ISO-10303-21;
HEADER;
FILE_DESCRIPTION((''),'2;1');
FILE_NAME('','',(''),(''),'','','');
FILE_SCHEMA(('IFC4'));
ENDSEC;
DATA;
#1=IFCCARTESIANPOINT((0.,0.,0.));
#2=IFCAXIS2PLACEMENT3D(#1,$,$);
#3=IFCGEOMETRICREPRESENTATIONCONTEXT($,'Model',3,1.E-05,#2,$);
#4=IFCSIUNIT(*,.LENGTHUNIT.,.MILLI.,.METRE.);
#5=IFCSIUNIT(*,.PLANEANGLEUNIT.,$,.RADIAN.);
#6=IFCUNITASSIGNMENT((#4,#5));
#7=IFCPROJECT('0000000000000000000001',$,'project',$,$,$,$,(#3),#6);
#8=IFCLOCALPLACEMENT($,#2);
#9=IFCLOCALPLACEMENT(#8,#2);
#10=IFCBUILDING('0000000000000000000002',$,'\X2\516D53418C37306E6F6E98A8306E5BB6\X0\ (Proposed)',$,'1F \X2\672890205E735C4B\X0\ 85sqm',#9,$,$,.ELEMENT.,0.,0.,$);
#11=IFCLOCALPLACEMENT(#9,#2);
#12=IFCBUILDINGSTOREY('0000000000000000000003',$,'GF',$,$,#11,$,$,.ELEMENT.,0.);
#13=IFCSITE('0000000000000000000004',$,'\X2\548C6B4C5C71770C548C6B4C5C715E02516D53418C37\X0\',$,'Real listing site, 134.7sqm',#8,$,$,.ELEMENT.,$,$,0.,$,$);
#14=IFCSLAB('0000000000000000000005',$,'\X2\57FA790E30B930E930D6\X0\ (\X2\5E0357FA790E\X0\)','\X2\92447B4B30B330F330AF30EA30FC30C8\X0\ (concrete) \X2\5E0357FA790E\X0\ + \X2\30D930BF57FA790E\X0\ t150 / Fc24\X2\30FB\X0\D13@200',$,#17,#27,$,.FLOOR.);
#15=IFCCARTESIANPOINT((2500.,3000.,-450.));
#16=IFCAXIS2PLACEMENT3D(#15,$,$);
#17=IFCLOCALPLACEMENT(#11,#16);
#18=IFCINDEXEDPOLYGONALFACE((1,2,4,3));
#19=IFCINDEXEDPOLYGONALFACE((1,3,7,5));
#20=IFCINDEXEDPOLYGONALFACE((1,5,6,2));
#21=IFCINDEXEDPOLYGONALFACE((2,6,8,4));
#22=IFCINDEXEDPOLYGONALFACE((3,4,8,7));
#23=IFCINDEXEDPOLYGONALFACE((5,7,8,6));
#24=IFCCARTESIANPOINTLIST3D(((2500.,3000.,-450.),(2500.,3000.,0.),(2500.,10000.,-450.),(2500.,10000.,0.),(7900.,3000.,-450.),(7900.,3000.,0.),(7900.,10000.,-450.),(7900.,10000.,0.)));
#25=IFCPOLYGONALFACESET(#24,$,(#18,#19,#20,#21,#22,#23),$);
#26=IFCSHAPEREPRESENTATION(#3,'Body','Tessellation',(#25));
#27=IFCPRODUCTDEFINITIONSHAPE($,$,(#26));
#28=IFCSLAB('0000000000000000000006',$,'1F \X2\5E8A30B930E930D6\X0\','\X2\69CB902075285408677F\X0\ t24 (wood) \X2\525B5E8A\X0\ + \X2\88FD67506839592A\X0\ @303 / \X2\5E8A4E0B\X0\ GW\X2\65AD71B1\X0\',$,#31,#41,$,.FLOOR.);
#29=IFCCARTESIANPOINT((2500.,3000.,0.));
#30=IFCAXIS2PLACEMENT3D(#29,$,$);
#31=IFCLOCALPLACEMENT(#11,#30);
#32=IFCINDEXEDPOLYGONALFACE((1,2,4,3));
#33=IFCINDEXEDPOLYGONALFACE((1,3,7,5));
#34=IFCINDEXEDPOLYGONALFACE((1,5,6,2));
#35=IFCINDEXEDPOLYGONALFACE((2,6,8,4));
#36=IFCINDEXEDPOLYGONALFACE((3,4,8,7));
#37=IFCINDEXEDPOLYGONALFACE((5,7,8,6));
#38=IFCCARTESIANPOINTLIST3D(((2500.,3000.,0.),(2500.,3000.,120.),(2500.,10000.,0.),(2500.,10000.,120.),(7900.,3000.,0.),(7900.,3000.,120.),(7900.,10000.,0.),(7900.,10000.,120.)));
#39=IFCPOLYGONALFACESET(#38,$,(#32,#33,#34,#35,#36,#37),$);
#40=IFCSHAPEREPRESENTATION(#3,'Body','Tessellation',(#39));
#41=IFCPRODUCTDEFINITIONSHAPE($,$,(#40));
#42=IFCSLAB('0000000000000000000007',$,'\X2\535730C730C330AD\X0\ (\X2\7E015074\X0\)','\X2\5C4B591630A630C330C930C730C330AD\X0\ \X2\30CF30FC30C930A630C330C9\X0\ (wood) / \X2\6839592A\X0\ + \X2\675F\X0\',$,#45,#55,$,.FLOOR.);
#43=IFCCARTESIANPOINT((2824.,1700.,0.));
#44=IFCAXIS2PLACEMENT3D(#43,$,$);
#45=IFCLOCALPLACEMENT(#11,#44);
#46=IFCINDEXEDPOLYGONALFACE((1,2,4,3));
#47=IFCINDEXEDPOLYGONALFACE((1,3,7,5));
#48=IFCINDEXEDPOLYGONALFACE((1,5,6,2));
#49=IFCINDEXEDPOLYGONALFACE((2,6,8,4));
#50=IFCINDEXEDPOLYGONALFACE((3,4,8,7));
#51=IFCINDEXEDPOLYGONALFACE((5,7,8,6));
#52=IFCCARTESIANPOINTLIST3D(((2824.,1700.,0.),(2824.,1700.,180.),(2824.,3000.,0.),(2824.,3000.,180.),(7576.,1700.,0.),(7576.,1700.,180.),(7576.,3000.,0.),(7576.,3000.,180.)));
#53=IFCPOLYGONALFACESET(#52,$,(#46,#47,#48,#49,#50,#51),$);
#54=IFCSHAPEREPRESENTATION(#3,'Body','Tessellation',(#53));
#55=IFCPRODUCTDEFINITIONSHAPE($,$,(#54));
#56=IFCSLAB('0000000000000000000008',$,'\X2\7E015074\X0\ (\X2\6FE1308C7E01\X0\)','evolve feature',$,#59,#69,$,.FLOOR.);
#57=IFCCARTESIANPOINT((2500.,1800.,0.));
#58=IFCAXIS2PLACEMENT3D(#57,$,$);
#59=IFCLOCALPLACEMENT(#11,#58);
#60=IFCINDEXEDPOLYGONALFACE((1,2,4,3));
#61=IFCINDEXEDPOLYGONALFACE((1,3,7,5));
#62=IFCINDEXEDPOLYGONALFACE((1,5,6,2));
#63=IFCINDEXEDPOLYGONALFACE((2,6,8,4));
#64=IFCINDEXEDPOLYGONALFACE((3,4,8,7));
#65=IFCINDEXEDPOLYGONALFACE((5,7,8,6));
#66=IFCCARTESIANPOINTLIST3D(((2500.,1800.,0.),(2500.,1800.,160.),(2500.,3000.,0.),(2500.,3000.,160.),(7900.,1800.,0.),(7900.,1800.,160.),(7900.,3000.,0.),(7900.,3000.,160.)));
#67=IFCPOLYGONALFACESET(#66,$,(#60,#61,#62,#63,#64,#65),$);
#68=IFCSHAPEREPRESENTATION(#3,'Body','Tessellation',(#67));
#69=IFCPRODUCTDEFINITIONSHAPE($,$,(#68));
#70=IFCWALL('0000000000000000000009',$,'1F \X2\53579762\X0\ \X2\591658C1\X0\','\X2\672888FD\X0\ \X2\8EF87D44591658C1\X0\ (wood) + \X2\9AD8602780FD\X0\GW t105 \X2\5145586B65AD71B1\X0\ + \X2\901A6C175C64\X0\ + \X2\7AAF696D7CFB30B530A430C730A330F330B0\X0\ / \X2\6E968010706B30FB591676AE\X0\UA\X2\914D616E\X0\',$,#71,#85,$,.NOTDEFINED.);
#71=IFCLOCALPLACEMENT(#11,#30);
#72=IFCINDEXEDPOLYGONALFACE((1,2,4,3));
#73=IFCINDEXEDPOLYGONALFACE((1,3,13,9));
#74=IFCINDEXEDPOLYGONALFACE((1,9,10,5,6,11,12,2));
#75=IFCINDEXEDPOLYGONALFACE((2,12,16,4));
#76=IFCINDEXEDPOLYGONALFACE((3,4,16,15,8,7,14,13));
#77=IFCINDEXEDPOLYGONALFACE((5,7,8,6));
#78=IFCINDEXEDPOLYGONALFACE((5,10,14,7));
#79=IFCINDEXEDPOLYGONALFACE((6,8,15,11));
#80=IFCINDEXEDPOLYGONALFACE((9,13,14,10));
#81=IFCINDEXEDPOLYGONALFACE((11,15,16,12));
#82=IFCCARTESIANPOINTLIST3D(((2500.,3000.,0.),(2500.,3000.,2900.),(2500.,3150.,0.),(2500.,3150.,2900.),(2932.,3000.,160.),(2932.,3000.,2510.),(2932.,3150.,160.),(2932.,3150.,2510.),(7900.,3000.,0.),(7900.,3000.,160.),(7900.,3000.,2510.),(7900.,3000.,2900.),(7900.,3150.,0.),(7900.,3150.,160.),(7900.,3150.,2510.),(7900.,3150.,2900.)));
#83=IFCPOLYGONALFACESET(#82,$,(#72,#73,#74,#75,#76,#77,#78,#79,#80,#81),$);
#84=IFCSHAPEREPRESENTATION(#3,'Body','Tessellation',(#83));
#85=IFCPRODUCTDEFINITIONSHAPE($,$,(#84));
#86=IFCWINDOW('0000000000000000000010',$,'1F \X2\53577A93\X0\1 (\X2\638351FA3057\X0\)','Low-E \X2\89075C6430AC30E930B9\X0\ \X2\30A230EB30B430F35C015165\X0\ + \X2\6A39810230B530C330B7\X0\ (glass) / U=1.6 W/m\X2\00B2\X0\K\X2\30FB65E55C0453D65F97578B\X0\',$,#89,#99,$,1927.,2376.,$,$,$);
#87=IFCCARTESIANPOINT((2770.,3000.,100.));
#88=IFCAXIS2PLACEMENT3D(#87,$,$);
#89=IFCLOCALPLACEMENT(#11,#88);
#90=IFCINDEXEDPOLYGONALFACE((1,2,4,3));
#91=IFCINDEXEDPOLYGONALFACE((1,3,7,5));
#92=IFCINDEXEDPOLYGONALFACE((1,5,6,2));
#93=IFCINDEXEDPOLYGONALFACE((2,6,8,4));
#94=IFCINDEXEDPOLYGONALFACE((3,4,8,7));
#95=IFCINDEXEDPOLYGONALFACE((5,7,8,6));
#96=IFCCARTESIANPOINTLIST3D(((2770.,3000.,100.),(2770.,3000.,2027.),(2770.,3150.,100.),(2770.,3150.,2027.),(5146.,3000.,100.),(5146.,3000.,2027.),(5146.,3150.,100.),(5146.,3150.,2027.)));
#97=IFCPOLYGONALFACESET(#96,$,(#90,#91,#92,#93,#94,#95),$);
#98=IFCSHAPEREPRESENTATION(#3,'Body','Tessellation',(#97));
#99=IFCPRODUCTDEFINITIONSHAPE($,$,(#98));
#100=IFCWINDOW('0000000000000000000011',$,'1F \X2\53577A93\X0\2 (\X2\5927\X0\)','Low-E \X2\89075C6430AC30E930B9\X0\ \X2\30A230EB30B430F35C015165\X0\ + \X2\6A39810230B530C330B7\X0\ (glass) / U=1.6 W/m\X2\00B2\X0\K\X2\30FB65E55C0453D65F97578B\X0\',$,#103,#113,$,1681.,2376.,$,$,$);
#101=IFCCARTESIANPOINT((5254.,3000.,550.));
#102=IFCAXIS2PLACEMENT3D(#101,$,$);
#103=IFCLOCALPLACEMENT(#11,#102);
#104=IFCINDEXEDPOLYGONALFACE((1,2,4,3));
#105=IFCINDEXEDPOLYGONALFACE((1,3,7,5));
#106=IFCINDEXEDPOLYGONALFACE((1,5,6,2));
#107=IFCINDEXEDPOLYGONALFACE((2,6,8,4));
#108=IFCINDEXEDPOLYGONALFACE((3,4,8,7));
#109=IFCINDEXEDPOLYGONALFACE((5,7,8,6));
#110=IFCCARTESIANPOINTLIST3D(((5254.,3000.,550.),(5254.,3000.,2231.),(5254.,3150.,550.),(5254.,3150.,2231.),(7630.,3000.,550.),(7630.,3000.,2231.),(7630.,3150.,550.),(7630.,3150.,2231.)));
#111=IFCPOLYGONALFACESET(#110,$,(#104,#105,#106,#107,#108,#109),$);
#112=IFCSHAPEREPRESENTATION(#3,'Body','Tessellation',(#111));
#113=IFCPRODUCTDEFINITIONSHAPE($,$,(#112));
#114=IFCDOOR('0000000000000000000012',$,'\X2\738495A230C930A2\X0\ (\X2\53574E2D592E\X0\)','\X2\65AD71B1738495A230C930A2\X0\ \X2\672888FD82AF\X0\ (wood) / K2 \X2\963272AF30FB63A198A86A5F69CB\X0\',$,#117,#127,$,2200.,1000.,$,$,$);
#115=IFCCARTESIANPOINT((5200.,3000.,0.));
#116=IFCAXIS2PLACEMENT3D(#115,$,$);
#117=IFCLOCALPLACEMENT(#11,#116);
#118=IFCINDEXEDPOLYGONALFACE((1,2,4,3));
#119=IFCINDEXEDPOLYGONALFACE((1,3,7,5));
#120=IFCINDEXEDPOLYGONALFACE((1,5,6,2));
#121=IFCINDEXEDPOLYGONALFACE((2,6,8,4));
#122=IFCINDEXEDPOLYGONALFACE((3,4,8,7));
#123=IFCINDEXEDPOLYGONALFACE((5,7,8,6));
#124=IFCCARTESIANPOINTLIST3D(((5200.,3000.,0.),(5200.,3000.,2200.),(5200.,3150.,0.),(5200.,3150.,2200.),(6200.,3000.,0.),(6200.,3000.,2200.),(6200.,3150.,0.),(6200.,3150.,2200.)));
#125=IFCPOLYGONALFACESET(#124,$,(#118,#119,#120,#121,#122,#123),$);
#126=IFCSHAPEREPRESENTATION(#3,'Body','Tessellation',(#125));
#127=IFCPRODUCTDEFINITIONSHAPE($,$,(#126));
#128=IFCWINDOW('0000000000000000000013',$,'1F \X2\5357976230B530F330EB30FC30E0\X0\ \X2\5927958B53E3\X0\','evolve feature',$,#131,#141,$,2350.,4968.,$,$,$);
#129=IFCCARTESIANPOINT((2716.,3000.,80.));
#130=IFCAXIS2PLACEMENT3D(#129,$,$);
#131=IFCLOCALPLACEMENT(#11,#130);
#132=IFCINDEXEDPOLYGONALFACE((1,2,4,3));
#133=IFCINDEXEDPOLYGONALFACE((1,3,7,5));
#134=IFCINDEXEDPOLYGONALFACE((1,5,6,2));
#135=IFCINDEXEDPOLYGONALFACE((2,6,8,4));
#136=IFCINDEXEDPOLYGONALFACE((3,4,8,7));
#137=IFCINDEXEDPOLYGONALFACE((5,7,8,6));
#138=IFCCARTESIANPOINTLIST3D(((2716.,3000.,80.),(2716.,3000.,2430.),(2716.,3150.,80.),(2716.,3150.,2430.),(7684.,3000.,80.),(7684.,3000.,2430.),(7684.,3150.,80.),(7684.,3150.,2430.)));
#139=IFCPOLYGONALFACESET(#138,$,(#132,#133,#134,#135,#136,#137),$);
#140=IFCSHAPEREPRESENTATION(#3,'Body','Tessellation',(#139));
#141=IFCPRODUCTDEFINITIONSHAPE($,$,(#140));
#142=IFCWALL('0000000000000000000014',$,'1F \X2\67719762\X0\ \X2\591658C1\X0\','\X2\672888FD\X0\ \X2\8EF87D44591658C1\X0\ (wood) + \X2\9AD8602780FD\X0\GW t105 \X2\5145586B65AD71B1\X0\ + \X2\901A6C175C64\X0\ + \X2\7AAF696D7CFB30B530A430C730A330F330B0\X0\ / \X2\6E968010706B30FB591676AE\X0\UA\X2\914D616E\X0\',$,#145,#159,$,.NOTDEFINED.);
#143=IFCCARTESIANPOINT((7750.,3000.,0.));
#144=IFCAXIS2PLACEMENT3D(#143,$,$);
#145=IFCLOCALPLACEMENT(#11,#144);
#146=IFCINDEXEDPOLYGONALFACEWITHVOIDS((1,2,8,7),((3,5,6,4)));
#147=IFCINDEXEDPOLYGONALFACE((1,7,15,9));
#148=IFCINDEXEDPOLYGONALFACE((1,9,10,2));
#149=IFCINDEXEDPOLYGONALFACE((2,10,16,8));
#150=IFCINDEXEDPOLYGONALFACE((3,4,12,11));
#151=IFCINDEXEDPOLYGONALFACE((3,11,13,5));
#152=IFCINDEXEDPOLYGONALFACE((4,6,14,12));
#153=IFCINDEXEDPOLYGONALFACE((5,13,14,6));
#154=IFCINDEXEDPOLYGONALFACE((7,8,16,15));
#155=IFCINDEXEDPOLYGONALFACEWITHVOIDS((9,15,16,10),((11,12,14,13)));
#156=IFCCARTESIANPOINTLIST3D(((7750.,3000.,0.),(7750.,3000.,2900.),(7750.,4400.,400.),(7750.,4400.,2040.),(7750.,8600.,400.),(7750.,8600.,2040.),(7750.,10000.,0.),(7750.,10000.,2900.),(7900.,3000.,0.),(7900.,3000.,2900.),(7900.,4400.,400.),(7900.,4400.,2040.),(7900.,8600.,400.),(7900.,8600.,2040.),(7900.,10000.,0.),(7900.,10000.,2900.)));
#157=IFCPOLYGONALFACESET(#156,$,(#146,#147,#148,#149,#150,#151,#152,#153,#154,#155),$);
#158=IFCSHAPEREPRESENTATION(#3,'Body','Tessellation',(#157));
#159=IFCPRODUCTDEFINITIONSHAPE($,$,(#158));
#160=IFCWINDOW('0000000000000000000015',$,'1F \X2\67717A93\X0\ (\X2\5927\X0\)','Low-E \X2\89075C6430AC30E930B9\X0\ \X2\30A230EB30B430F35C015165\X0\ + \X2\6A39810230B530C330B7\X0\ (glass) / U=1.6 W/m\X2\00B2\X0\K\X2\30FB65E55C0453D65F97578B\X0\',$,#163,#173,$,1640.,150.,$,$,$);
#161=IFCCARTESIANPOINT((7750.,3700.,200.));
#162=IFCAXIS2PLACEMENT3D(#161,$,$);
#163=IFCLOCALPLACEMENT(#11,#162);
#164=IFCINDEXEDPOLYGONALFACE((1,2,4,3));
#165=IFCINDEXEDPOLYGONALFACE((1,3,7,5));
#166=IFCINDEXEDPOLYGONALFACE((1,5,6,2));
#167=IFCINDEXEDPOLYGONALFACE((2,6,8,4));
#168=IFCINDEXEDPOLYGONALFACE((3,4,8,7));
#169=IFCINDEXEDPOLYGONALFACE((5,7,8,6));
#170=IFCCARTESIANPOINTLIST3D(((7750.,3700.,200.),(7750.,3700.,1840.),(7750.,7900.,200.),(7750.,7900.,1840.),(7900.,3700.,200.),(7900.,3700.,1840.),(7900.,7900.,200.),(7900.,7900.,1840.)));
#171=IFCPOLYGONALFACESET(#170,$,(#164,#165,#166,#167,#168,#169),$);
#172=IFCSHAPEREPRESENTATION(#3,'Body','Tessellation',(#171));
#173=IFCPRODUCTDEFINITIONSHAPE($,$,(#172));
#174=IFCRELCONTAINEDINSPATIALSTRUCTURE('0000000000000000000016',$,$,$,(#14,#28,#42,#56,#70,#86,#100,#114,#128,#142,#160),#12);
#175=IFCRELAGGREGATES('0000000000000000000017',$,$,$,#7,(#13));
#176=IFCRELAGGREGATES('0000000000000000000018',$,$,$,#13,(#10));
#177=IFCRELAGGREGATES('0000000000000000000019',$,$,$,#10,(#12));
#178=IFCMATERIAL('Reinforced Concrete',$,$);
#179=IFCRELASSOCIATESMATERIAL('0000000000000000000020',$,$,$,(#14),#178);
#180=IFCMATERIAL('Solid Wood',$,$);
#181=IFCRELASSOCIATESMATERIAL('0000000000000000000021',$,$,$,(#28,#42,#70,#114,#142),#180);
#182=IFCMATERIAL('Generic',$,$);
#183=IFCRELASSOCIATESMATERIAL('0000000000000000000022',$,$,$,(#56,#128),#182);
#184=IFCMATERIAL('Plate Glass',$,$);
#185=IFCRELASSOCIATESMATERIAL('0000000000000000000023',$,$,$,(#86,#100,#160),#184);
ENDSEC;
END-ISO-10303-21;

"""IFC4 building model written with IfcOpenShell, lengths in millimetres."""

from ifc_helpers import new_model, si_unit, frame, frame_2d, origin, place, context, project, spatial, rectangle, extrude, material, element, fill, save


model = new_model("IFC4")

# Units and contexts
model_context = context("Model", 3, precision=1e-05, world=origin())
ifc_project = project(units=[si_unit("LENGTHUNIT", "METRE", prefix="MILLI"), si_unit("PLANEANGLEUNIT", "RADIAN")], contexts=[model_context])

# Site, building, storey
site_placement = place(None, origin())
site = spatial("IfcSite", under=ifc_project, at=site_placement, Name="和歌山県和歌山市六十谷", ObjectType="Real listing site, 134.7sqm", CompositionType="ELEMENT", RefElevation=0.0)
building_placement = place(site_placement, origin())
building = spatial("IfcBuilding", under=site, at=building_placement, Name="六十谷の潮風の家 (Proposed)", ObjectType="1F 木造平屋 85sqm", CompositionType="ELEMENT", ElevationOfRefHeight=0.0, ElevationOfTerrain=0.0)
storey_placement = place(building_placement, origin())
storey = spatial("IfcBuildingStorey", under=building, at=storey_placement, Name="GF", CompositionType="ELEMENT", Elevation=0.0)

# Slabs
ifc_material_1 = material(Name="Reinforced Concrete")
slab_1_placement = place(storey_placement, frame((2500.0, 3000.0, -450.0)))
element("IfcSlab", 1, at=slab_1_placement, inside=storey, material=ifc_material_1, Name="基礎スラブ (布基礎)", Description="鉄筋コンクリート (concrete) 布基礎 + ベタ基礎 t150 / Fc24・D13@200", PredefinedType="FLOOR", context=model_context, shape_type="SweptSolid", body=[
    extrude(rectangle(XDim=5400.0, YDim=7000.0, at=frame_2d((2700.0, 3500.0))), frame((2500.0, 3000.0, -450.0)), (0.0, 0.0, 1.0), 450.0),
])
ifc_material_2 = material(Name="Solid Wood")
slab_2_placement = place(storey_placement, frame((2500.0, 3000.0, 0.0)))
element("IfcSlab", 2, at=slab_2_placement, inside=storey, material=ifc_material_2, Name="1F 床スラブ", Description="構造用合板 t24 (wood) 剛床 + 製材根太 @303 / 床下 GW断熱", PredefinedType="FLOOR", context=model_context, shape_type="SweptSolid", body=[
    extrude(rectangle(XDim=5400.0, YDim=7000.0, at=frame_2d((2700.0, 3500.0))), frame((2500.0, 3000.0, 0.0)), (0.0, 0.0, 1.0), 120.0),
])
slab_3_placement = place(storey_placement, frame((2824.0, 1700.0, 0.0)))
element("IfcSlab", 3, at=slab_3_placement, inside=storey, material=ifc_material_2, Name="南デッキ (縁側)", Description="屋外ウッドデッキ ハードウッド (wood) / 根太 + 束", PredefinedType="FLOOR", context=model_context, shape_type="SweptSolid", body=[
    extrude(rectangle(XDim=4752.0, YDim=1300.0, at=frame_2d((2376.0, 650.0))), frame((2824.0, 1700.0, 0.0)), (0.0, 0.0, 1.0), 180.0),
])
ifc_material_3 = material(Name="Generic")
slab_4_placement = place(storey_placement, frame((2500.0, 1800.0, 0.0)))
element("IfcSlab", 4, at=slab_4_placement, inside=storey, material=ifc_material_3, Name="縁側 (濡れ縁)", Description="evolve feature", PredefinedType="FLOOR", context=model_context, shape_type="SweptSolid", body=[
    extrude(rectangle(XDim=5400.0, YDim=1200.0, at=frame_2d((2700.0, 600.0))), frame((2500.0, 1800.0, 0.0)), (0.0, 0.0, 1.0), 160.0),
])

# Wall, openings, windows, door
wall_1_placement = place(storey_placement, frame((2500.0, 3000.0, 0.0)))
wall_1 = element("IfcWall", 5, at=wall_1_placement, inside=storey, material=ifc_material_2, Name="1F 南面 外壁", Description="木製 軸組外壁 (wood) + 高性能GW t105 充填断熱 + 通気層 + 窯業系サイディング / 準耐火・外皮UA配慮", PredefinedType="NOTDEFINED", context=model_context, shape_type="SweptSolid", body=[
    extrude(rectangle(XDim=5400.0, YDim=150.0, at=frame_2d((2700.0, 75.0))), frame((2500.0, 3000.0, 0.0)), (0.0, 0.0, 1.0), 2900.0),
])
opening_1_placement = place(storey_placement, frame((2770.0, 3000.0, 100.0)))
opening_1 = element("IfcOpeningElement", 6, at=opening_1_placement, cuts=wall_1, PredefinedType="NOTDEFINED", context=model_context, shape_type="SweptSolid", body=[
    extrude(rectangle(XDim=2376.0, YDim=150.0, at=frame_2d((1188.0, 75.0))), frame((2770.0, 3000.0, 100.0)), (0.0, 0.0, 1.0), 1927.0),
])
opening_2_placement = place(storey_placement, frame((5254.0, 3000.0, 550.0)))
opening_2 = element("IfcOpeningElement", 7, at=opening_2_placement, cuts=wall_1, PredefinedType="NOTDEFINED", context=model_context, shape_type="SweptSolid", body=[
    extrude(rectangle(XDim=2376.0, YDim=150.0, at=frame_2d((1188.0, 75.0))), frame((5254.0, 3000.0, 550.0)), (0.0, 0.0, 1.0), 1681.0),
])
opening_3_placement = place(storey_placement, frame((5200.0, 3000.0, 0.0)))
opening_3 = element("IfcOpeningElement", 8, at=opening_3_placement, cuts=wall_1, PredefinedType="NOTDEFINED", context=model_context, shape_type="SweptSolid", body=[
    extrude(rectangle(XDim=1000.0, YDim=150.0, at=frame_2d((500.0, 75.0))), frame((5200.0, 3000.0, 0.0)), (0.0, 0.0, 1.0), 2200.0),
])
opening_4_placement = place(storey_placement, frame((2716.0, 3000.0, 80.0)))
opening_4 = element("IfcOpeningElement", 9, at=opening_4_placement, cuts=wall_1, PredefinedType="NOTDEFINED", context=model_context, shape_type="SweptSolid", body=[
    extrude(rectangle(XDim=4968.0, YDim=150.0, at=frame_2d((2484.0, 75.0))), frame((2716.0, 3000.0, 80.0)), (0.0, 0.0, 1.0), 2350.0),
])
ifc_material_4 = material(Name="Plate Glass")
window_1_placement = place(storey_placement, frame((2770.0, 3000.0, 100.0)))
window_1 = element("IfcWindow", 10, at=window_1_placement, inside=storey, material=ifc_material_4, Name="1F 南窓1 (掃出し)", Description="Low-E 複層ガラス アルゴン封入 + 樹脂サッシ (glass) / U=1.6 W/m²K・日射取得型", OverallHeight=1927.0, OverallWidth=2376.0, context=model_context, shape_type="SweptSolid", body=[
    extrude(rectangle(XDim=2376.0, YDim=150.0, at=frame_2d((1188.0, 75.0))), frame((2770.0, 3000.0, 100.0)), (0.0, 0.0, 1.0), 1927.0),
])
fill(opening_1, window_1)
window_2_placement = place(storey_placement, frame((5254.0, 3000.0, 550.0)))
window_2 = element("IfcWindow", 11, at=window_2_placement, inside=storey, material=ifc_material_4, Name="1F 南窓2 (大)", Description="Low-E 複層ガラス アルゴン封入 + 樹脂サッシ (glass) / U=1.6 W/m²K・日射取得型", OverallHeight=1681.0, OverallWidth=2376.0, context=model_context, shape_type="SweptSolid", body=[
    extrude(rectangle(XDim=2376.0, YDim=150.0, at=frame_2d((1188.0, 75.0))), frame((5254.0, 3000.0, 550.0)), (0.0, 0.0, 1.0), 1681.0),
])
fill(opening_2, window_2)
door_placement = place(storey_placement, frame((5200.0, 3000.0, 0.0)))
door = element("IfcDoor", 12, at=door_placement, inside=storey, material=ifc_material_2, Name="玄関ドア (南中央)", Description="断熱玄関ドア 木製芯 (wood) / K2 防犯・採風機構", OverallHeight=2200.0, OverallWidth=1000.0, context=model_context, shape_type="SweptSolid", body=[
    extrude(rectangle(XDim=1000.0, YDim=150.0, at=frame_2d((500.0, 75.0))), frame((5200.0, 3000.0, 0.0)), (0.0, 0.0, 1.0), 2200.0),
])
fill(opening_3, door)
window_3_placement = place(storey_placement, frame((2716.0, 3000.0, 80.0)))
window_3 = element("IfcWindow", 13, at=window_3_placement, inside=storey, material=ifc_material_3, Name="1F 南面サンルーム 大開口", Description="evolve feature", OverallHeight=2350.0, OverallWidth=4968.0, context=model_context, shape_type="SweptSolid", body=[
    extrude(rectangle(XDim=4968.0, YDim=150.0, at=frame_2d((2484.0, 75.0))), frame((2716.0, 3000.0, 80.0)), (0.0, 0.0, 1.0), 2350.0),
])
fill(opening_4, window_3)

# Wall, opening, window
wall_2_placement = place(storey_placement, frame((7750.0, 3000.0, 0.0)))
wall_2 = element("IfcWall", 14, at=wall_2_placement, inside=storey, material=ifc_material_2, Name="1F 東面 外壁", Description="木製 軸組外壁 (wood) + 高性能GW t105 充填断熱 + 通気層 + 窯業系サイディング / 準耐火・外皮UA配慮", PredefinedType="NOTDEFINED", context=model_context, shape_type="SweptSolid", body=[
    extrude(rectangle(XDim=150.0, YDim=7000.0, at=frame_2d((75.0, 3500.0))), frame((7750.0, 3000.0, 0.0)), (0.0, 0.0, 1.0), 2900.0),
])
opening_5_placement = place(storey_placement, frame((7750.0, 3700.0, 200.0)))
opening_5 = element("IfcOpeningElement", 15, at=opening_5_placement, cuts=wall_2, PredefinedType="NOTDEFINED", context=model_context, shape_type="SweptSolid", body=[
    extrude(rectangle(XDim=150.0, YDim=4200.0, at=frame_2d((75.0, 2100.0))), frame((7750.0, 3700.0, 200.0)), (0.0, 0.0, 1.0), 1640.0),
])
window_4_placement = place(storey_placement, frame((7750.0, 3700.0, 200.0)))
window_4 = element("IfcWindow", 16, at=window_4_placement, inside=storey, material=ifc_material_4, Name="1F 東窓 (大)", Description="Low-E 複層ガラス アルゴン封入 + 樹脂サッシ (glass) / U=1.6 W/m²K・日射取得型", OverallHeight=1640.0, OverallWidth=150.0, context=model_context, shape_type="SweptSolid", body=[
    extrude(rectangle(XDim=150.0, YDim=4200.0, at=frame_2d((75.0, 2100.0))), frame((7750.0, 3700.0, 200.0)), (0.0, 0.0, 1.0), 1640.0),
])
fill(opening_5, window_4)

save(model, "model.ifc")
